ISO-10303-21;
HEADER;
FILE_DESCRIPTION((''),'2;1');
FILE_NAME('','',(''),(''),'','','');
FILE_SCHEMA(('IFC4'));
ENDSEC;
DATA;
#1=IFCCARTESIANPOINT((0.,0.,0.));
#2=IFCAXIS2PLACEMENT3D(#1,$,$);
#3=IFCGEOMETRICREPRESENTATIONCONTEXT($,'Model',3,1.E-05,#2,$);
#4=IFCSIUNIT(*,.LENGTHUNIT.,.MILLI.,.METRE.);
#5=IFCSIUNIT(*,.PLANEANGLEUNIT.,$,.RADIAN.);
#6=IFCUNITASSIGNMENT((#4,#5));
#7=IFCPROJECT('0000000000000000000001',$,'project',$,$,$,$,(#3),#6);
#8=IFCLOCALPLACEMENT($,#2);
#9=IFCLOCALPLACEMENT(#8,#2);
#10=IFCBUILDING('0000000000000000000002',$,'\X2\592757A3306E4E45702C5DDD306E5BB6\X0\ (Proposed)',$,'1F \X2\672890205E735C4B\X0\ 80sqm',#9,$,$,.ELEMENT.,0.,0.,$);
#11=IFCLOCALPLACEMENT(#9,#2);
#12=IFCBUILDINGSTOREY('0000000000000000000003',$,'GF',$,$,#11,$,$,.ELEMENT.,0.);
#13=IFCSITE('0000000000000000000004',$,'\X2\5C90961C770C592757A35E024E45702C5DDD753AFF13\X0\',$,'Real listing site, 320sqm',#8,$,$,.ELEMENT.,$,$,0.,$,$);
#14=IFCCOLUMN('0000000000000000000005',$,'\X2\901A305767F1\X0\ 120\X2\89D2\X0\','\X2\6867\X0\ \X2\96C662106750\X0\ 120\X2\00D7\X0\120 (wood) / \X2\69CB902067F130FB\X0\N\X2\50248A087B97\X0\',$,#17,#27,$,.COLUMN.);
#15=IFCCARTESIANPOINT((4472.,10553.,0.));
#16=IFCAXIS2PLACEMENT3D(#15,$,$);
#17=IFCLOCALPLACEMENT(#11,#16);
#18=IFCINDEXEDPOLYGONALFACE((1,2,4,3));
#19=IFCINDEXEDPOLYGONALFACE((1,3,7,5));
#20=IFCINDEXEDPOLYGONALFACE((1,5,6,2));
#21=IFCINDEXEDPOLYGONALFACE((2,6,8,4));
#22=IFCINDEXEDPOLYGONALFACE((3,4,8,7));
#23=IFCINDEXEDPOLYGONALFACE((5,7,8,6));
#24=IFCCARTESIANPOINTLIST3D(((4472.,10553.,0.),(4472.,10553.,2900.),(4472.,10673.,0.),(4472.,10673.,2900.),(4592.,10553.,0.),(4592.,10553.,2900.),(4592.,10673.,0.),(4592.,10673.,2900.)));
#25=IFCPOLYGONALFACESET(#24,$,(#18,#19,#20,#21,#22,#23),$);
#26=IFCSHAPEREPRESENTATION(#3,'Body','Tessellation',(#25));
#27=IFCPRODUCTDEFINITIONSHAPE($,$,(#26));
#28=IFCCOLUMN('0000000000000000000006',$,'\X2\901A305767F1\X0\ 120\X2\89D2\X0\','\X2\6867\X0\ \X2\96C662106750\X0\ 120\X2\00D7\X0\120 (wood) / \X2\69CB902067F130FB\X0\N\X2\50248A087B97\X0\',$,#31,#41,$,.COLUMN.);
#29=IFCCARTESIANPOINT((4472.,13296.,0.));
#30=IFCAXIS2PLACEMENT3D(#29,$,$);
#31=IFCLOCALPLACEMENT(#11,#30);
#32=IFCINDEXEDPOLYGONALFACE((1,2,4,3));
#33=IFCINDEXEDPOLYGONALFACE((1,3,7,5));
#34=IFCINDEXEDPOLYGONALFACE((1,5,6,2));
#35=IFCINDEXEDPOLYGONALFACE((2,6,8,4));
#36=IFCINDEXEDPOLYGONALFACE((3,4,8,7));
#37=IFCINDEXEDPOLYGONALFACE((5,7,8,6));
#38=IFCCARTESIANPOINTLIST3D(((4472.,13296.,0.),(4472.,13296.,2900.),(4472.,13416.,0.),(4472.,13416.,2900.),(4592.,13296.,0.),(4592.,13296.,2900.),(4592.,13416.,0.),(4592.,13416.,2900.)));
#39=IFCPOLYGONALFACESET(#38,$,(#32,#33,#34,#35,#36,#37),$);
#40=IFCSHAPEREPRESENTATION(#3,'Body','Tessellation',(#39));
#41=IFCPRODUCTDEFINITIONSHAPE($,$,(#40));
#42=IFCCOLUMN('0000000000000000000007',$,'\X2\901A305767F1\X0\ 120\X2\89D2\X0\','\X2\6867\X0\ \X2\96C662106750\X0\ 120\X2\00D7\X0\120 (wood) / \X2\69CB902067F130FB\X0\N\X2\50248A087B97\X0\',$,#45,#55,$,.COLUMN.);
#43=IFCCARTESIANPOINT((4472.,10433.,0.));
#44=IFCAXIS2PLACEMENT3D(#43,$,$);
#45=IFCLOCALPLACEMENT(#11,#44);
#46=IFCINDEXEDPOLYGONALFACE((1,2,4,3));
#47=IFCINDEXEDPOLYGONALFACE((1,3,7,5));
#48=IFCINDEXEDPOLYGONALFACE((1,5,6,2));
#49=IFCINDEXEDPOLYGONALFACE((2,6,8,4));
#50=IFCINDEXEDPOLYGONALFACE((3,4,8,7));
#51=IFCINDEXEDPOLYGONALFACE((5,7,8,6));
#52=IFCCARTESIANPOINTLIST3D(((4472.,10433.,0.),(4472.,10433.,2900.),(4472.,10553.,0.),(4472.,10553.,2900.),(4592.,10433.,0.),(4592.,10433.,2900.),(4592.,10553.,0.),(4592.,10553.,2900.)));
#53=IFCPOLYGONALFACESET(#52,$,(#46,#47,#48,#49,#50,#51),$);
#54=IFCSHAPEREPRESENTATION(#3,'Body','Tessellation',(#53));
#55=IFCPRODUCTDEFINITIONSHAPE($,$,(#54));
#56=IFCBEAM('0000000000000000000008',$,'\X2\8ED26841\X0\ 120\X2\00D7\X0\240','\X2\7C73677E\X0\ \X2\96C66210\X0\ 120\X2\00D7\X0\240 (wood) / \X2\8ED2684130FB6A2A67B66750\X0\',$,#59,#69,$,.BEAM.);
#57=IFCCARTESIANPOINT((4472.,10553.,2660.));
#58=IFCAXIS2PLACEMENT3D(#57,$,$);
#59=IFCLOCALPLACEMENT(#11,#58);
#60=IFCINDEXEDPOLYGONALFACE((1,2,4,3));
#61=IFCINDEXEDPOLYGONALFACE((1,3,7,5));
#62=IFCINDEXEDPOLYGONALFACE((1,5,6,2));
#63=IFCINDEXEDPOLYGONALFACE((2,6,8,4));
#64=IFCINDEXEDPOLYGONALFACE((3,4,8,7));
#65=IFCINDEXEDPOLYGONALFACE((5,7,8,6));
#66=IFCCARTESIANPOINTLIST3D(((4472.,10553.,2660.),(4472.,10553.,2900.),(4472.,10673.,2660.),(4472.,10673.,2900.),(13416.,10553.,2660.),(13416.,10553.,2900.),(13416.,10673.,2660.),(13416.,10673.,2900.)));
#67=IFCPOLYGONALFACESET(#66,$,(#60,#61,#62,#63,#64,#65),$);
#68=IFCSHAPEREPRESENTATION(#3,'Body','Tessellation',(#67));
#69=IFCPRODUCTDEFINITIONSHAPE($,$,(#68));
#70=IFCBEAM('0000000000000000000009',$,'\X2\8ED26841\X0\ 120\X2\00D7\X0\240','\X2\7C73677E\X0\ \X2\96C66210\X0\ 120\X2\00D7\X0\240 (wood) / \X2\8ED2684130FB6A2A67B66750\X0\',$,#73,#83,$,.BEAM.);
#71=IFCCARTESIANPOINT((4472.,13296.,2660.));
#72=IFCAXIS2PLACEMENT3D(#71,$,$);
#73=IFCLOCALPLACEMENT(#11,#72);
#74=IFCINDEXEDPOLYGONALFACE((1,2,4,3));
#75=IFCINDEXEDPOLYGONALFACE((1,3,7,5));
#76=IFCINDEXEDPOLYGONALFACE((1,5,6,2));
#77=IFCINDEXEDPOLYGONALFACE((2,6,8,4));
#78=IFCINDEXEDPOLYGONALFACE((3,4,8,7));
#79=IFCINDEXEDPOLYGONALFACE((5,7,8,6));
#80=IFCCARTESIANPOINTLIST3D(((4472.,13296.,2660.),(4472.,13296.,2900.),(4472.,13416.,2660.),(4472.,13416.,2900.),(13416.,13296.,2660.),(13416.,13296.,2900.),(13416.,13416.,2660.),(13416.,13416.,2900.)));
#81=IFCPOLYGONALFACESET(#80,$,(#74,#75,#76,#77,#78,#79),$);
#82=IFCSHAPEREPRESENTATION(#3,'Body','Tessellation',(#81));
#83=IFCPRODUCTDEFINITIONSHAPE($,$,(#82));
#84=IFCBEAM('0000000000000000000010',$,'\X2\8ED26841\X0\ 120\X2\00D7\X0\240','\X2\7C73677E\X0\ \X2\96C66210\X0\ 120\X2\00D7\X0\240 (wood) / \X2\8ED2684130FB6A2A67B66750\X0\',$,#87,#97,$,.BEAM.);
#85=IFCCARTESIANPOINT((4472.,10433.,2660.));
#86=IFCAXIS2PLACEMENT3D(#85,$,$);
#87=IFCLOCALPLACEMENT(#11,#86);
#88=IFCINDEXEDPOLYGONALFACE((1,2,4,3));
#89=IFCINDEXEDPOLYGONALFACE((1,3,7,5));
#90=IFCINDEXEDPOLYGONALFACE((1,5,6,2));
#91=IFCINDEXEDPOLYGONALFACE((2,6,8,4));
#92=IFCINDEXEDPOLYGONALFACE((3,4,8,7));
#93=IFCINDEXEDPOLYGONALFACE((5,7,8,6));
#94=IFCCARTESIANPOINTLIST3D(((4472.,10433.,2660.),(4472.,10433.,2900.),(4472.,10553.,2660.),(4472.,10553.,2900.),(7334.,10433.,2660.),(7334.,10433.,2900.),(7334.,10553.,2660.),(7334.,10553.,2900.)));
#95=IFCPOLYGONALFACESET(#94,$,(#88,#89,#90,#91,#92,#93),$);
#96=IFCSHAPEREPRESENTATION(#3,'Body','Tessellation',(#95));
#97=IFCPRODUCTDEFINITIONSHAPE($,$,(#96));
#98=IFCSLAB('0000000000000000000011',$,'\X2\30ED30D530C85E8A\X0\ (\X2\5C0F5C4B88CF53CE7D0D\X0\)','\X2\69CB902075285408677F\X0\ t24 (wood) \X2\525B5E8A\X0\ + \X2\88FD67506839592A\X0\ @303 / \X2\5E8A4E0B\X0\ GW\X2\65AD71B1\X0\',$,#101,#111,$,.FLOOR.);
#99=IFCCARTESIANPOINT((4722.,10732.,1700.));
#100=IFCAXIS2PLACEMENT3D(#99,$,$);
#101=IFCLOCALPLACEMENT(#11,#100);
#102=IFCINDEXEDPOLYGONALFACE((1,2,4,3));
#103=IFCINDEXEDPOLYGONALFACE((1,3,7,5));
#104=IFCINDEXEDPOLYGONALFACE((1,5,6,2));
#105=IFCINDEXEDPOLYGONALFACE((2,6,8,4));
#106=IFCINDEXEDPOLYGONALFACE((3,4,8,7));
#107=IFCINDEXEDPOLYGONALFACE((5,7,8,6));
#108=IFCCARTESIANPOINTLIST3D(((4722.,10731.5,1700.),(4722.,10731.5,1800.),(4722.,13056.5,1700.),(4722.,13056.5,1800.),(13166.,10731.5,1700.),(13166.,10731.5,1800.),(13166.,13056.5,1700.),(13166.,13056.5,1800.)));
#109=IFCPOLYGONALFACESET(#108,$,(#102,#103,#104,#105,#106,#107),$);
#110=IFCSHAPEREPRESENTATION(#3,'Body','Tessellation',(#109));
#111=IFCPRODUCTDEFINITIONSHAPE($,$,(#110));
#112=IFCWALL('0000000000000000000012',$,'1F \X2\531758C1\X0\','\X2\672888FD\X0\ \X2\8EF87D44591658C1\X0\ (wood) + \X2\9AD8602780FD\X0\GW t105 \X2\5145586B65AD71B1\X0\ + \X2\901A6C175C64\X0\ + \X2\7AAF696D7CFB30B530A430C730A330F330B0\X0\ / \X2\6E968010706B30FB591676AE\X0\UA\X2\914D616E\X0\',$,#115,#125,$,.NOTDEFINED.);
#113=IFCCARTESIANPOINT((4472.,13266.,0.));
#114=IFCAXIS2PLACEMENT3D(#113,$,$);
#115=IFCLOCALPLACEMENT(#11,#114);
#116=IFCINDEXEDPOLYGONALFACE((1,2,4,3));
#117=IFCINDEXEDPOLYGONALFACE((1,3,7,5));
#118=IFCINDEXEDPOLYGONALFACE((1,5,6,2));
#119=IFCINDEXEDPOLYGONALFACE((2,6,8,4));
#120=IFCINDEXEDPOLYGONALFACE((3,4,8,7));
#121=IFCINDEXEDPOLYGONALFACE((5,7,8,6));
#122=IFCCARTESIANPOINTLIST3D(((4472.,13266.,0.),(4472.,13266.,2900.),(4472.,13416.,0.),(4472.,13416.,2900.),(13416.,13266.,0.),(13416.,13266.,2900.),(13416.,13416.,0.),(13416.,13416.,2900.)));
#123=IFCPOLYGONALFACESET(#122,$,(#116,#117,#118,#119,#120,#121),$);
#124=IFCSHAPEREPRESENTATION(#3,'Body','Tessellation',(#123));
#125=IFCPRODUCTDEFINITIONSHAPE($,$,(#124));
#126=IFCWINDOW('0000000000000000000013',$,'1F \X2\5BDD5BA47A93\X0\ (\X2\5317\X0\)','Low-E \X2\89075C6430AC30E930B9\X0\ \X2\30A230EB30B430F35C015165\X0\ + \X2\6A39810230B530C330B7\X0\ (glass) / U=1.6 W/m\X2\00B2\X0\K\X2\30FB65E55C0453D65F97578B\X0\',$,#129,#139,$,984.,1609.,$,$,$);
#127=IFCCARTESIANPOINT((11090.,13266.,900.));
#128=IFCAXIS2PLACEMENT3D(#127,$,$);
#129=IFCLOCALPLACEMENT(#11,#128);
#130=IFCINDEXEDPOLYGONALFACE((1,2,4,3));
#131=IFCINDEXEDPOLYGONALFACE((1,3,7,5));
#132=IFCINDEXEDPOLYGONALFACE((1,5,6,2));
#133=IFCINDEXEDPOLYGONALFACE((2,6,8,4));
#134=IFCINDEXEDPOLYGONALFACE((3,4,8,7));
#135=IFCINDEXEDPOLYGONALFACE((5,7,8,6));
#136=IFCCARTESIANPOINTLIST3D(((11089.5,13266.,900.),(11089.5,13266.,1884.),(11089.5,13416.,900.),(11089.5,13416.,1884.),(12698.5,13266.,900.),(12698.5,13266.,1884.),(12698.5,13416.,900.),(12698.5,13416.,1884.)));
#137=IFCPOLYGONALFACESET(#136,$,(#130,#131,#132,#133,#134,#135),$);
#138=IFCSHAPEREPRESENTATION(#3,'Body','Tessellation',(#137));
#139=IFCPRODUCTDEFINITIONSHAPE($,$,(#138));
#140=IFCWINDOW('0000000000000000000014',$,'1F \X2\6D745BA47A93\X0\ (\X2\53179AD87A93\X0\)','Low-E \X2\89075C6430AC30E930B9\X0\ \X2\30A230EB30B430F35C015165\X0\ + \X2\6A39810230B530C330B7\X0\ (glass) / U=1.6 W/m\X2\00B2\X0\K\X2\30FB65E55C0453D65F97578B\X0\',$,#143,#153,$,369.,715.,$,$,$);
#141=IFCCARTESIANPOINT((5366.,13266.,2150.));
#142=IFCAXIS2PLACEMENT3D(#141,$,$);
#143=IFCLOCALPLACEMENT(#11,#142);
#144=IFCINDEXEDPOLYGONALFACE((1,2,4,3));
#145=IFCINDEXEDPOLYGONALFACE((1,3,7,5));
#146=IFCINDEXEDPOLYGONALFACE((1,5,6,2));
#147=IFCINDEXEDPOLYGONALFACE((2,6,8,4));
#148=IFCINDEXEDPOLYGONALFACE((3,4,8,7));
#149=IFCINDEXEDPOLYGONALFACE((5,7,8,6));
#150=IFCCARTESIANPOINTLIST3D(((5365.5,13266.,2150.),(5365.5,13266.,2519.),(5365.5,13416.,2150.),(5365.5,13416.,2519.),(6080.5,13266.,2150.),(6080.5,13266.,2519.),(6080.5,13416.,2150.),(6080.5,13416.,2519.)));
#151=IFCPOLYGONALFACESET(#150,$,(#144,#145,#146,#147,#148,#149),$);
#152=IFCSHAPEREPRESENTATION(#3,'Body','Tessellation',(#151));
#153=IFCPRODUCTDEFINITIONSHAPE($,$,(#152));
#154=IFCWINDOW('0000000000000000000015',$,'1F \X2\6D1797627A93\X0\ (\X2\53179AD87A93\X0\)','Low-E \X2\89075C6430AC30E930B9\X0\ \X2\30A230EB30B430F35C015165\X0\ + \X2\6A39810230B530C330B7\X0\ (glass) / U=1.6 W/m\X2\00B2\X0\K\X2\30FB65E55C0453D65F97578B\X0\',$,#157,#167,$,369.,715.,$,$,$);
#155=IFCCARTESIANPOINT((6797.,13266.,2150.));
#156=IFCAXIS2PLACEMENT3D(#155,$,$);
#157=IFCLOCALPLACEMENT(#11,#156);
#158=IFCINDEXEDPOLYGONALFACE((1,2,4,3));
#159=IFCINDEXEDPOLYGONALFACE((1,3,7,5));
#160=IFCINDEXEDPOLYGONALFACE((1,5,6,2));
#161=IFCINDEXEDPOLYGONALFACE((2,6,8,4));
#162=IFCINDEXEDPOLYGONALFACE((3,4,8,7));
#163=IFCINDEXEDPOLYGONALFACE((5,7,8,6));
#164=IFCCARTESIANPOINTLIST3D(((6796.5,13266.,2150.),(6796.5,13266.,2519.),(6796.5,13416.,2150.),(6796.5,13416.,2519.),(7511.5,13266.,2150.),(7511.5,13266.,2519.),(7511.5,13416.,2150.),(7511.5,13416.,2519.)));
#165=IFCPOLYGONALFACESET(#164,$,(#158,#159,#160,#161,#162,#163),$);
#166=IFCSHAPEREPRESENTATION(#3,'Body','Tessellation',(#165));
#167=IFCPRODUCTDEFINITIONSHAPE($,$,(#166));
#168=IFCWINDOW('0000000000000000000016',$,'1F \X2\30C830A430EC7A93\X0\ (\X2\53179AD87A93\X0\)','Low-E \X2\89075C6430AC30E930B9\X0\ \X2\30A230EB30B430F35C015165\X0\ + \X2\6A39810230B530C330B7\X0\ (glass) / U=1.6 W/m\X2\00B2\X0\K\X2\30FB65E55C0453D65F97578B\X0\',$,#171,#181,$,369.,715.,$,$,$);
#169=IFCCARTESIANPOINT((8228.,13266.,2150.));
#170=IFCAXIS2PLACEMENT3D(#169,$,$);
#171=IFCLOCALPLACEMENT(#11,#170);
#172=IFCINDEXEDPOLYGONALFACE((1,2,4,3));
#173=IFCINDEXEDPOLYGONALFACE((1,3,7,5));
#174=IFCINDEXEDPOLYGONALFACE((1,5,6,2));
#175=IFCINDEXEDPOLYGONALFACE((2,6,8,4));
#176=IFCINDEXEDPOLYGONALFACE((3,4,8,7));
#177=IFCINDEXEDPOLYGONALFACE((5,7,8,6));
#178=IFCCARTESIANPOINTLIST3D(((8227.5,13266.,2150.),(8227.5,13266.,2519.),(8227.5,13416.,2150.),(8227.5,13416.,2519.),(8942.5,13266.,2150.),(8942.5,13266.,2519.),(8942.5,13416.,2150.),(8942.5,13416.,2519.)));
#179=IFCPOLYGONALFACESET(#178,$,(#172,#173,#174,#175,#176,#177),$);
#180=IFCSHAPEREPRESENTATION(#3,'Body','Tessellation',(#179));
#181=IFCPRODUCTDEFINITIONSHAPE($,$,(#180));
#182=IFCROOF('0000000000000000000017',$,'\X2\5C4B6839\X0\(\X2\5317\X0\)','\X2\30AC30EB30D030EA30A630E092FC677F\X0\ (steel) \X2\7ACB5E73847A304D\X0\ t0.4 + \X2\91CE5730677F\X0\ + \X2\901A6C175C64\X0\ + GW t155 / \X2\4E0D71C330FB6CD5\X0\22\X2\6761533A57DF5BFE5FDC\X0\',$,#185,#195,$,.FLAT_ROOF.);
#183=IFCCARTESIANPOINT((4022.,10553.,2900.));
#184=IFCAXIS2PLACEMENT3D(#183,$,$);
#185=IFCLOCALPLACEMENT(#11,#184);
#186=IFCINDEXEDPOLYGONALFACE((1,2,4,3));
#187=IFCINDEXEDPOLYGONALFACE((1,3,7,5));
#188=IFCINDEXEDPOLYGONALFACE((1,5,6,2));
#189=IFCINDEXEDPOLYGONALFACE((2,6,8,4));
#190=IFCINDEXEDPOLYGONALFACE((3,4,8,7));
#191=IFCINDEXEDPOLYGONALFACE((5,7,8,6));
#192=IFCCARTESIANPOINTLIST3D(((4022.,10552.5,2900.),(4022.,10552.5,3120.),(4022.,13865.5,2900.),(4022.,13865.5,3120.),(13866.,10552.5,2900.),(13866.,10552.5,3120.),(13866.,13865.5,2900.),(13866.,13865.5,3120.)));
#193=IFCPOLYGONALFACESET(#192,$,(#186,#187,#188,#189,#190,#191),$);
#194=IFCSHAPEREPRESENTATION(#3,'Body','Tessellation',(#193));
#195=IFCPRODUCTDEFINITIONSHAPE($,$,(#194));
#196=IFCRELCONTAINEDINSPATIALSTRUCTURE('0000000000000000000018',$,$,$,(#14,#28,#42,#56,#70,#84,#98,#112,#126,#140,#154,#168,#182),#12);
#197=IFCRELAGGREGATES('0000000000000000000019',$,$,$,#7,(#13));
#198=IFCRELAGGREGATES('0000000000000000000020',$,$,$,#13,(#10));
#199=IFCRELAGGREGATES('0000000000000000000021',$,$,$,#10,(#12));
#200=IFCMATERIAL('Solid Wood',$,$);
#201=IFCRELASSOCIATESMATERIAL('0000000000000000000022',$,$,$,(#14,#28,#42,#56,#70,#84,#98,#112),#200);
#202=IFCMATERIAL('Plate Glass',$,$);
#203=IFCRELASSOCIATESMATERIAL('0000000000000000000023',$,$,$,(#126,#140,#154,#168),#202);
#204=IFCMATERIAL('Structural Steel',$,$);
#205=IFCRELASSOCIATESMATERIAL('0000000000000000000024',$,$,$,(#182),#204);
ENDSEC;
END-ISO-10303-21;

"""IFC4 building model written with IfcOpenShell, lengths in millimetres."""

from ifc_helpers import new_model, si_unit, frame, frame_2d, origin, place, context, project, spatial, rectangle, extrude, material, element, fill, save


model = new_model("IFC4")

# Units and contexts
model_context = context("Model", 3, precision=1e-05, world=origin())
ifc_project = project(units=[si_unit("LENGTHUNIT", "METRE", prefix="MILLI"), si_unit("PLANEANGLEUNIT", "RADIAN")], contexts=[model_context])

# Site, building, storey
site_placement = place(None, origin())
site = spatial("IfcSite", under=ifc_project, at=site_placement, Name="岐阜県大垣市久瀬川町３", ObjectType="Real listing site, 320sqm", CompositionType="ELEMENT", RefElevation=0.0)
building_placement = place(site_placement, origin())
building = spatial("IfcBuilding", under=site, at=building_placement, Name="大垣の久瀬川の家 (Proposed)", ObjectType="1F 木造平屋 80sqm", CompositionType="ELEMENT", ElevationOfRefHeight=0.0, ElevationOfTerrain=0.0)
storey_placement = place(building_placement, origin())
storey = spatial("IfcBuildingStorey", under=building, at=storey_placement, Name="GF", CompositionType="ELEMENT", Elevation=0.0)

# Columns
ifc_material_1 = material(Name="Solid Wood")
column_1_placement = place(storey_placement, frame((4472.0, 10553.0, 0.0)))
element("IfcColumn", 1, at=column_1_placement, inside=storey, material=ifc_material_1, Name="通し柱 120角", Description="桧 集成材 120×120 (wood) / 構造柱・N値計算", PredefinedType="COLUMN", context=model_context, shape_type="SweptSolid", body=[
    extrude(rectangle(XDim=120.0, YDim=120.0, at=frame_2d((60.0, 60.0))), frame((4472.0, 10553.0, 0.0)), (0.0, 0.0, 1.0), 2900.0),
])
column_2_placement = place(storey_placement, frame((4472.0, 13296.0, 0.0)))
element("IfcColumn", 2, at=column_2_placement, inside=storey, material=ifc_material_1, Name="通し柱 120角", Description="桧 集成材 120×120 (wood) / 構造柱・N値計算", PredefinedType="COLUMN", context=model_context, shape_type="SweptSolid", body=[
    extrude(rectangle(XDim=120.0, YDim=120.0, at=frame_2d((60.0, 60.0))), frame((4472.0, 13296.0, 0.0)), (0.0, 0.0, 1.0), 2900.0),
])
column_3_placement = place(storey_placement, frame((4472.0, 10433.0, 0.0)))
element("IfcColumn", 3, at=column_3_placement, inside=storey, material=ifc_material_1, Name="通し柱 120角", Description="桧 集成材 120×120 (wood) / 構造柱・N値計算", PredefinedType="COLUMN", context=model_context, shape_type="SweptSolid", body=[
    extrude(rectangle(XDim=120.0, YDim=120.0, at=frame_2d((60.0, 60.0))), frame((4472.0, 10433.0, 0.0)), (0.0, 0.0, 1.0), 2900.0),
])

# Beams
beam_1_placement = place(storey_placement, frame((4472.0, 10553.0, 2660.0)))
element("IfcBeam", 4, at=beam_1_placement, inside=storey, material=ifc_material_1, Name="軒桁 120×240", Description="米松 集成 120×240 (wood) / 軒桁・横架材", PredefinedType="BEAM", context=model_context, shape_type="SweptSolid", body=[
    extrude(rectangle(XDim=8944.0, YDim=120.0, at=frame_2d((4472.0, 60.0))), frame((4472.0, 10553.0, 2660.0)), (0.0, 0.0, 1.0), 240.0),
])
beam_2_placement = place(storey_placement, frame((4472.0, 13296.0, 2660.0)))
element("IfcBeam", 5, at=beam_2_placement, inside=storey, material=ifc_material_1, Name="軒桁 120×240", Description="米松 集成 120×240 (wood) / 軒桁・横架材", PredefinedType="BEAM", context=model_context, shape_type="SweptSolid", body=[
    extrude(rectangle(XDim=8944.0, YDim=120.0, at=frame_2d((4472.0, 60.0))), frame((4472.0, 13296.0, 2660.0)), (0.0, 0.0, 1.0), 240.0),
])
beam_3_placement = place(storey_placement, frame((4472.0, 10433.0, 2660.0)))
element("IfcBeam", 6, at=beam_3_placement, inside=storey, material=ifc_material_1, Name="軒桁 120×240", Description="米松 集成 120×240 (wood) / 軒桁・横架材", PredefinedType="BEAM", context=model_context, shape_type="SweptSolid", body=[
    extrude(rectangle(XDim=2862.0, YDim=120.0, at=frame_2d((1431.0, 60.0))), frame((4472.0, 10433.0, 2660.0)), (0.0, 0.0, 1.0), 240.0),
])

# Slab
slab_1_placement = place(storey_placement, frame((4722.0, 10732.0, 1700.0)))
element("IfcSlab", 7, at=slab_1_placement, inside=storey, material=ifc_material_1, Name="ロフト床 (小屋裏収納)", Description="構造用合板 t24 (wood) 剛床 + 製材根太 @303 / 床下 GW断熱", PredefinedType="FLOOR", context=model_context, shape_type="SweptSolid", body=[
    extrude(rectangle(XDim=8444.0, YDim=2325.0, at=frame_2d((4222.0, 1162.0))), frame((4722.0, 10732.0, 1700.0)), (0.0, 0.0, 1.0), 100.0),
])

# Wall, openings, windows
wall_1_placement = place(storey_placement, frame((4472.0, 13266.0, 0.0)))
wall_1 = element("IfcWall", 8, at=wall_1_placement, inside=storey, material=ifc_material_1, Name="1F 北壁", Description="木製 軸組外壁 (wood) + 高性能GW t105 充填断熱 + 通気層 + 窯業系サイディング / 準耐火・外皮UA配慮", PredefinedType="NOTDEFINED", context=model_context, shape_type="SweptSolid", body=[
    extrude(rectangle(XDim=8944.0, YDim=150.0, at=frame_2d((4472.0, 75.0))), frame((4472.0, 13266.0, 0.0)), (0.0, 0.0, 1.0), 2900.0),
])
opening_1_placement = place(storey_placement, frame((11090.0, 13266.0, 900.0)))
opening_1 = element("IfcOpeningElement", 9, at=opening_1_placement, cuts=wall_1, PredefinedType="NOTDEFINED", context=model_context, shape_type="SweptSolid", body=[
    extrude(rectangle(XDim=1609.0, YDim=150.0, at=frame_2d((804.0, 75.0))), frame((11090.0, 13266.0, 900.0)), (0.0, 0.0, 1.0), 984.0),
])
opening_2_placement = place(storey_placement, frame((5366.0, 13266.0, 2150.0)))
opening_2 = element("IfcOpeningElement", 10, at=opening_2_placement, cuts=wall_1, PredefinedType="NOTDEFINED", context=model_context, shape_type="SweptSolid", body=[
    extrude(rectangle(XDim=715.0, YDim=150.0, at=frame_2d((357.0, 75.0))), frame((5366.0, 13266.0, 2150.0)), (0.0, 0.0, 1.0), 369.0),
])
opening_3_placement = place(storey_placement, frame((6797.0, 13266.0, 2150.0)))
opening_3 = element("IfcOpeningElement", 11, at=opening_3_placement, cuts=wall_1, PredefinedType="NOTDEFINED", context=model_context, shape_type="SweptSolid", body=[
    extrude(rectangle(XDim=715.0, YDim=150.0, at=frame_2d((357.0, 75.0))), frame((6797.0, 13266.0, 2150.0)), (0.0, 0.0, 1.0), 369.0),
])
opening_4_placement = place(storey_placement, frame((8228.0, 13266.0, 2150.0)))
opening_4 = element("IfcOpeningElement", 12, at=opening_4_placement, cuts=wall_1, PredefinedType="NOTDEFINED", context=model_context, shape_type="SweptSolid", body=[
    extrude(rectangle(XDim=715.0, YDim=150.0, at=frame_2d((357.0, 75.0))), frame((8228.0, 13266.0, 2150.0)), (0.0, 0.0, 1.0), 369.0),
])
ifc_material_2 = material(Name="Plate Glass")
window_1_placement = place(storey_placement, frame((11090.0, 13266.0, 900.0)))
window_1 = element("IfcWindow", 13, at=window_1_placement, inside=storey, material=ifc_material_2, Name="1F 寝室窓 (北)", Description="Low-E 複層ガラス アルゴン封入 + 樹脂サッシ (glass) / U=1.6 W/m²K・日射取得型", OverallHeight=984.0, OverallWidth=1609.0, context=model_context, shape_type="SweptSolid", body=[
    extrude(rectangle(XDim=1609.0, YDim=150.0, at=frame_2d((804.0, 75.0))), frame((11090.0, 13266.0, 900.0)), (0.0, 0.0, 1.0), 984.0),
])
fill(opening_1, window_1)
window_2_placement = place(storey_placement, frame((5366.0, 13266.0, 2150.0)))
window_2 = element("IfcWindow", 14, at=window_2_placement, inside=storey, material=ifc_material_2, Name="1F 浴室窓 (北高窓)", Description="Low-E 複層ガラス アルゴン封入 + 樹脂サッシ (glass) / U=1.6 W/m²K・日射取得型", OverallHeight=369.0, OverallWidth=715.0, context=model_context, shape_type="SweptSolid", body=[
    extrude(rectangle(XDim=715.0, YDim=150.0, at=frame_2d((357.0, 75.0))), frame((5366.0, 13266.0, 2150.0)), (0.0, 0.0, 1.0), 369.0),
])
fill(opening_2, window_2)
window_3_placement = place(storey_placement, frame((6797.0, 13266.0, 2150.0)))
window_3 = element("IfcWindow", 15, at=window_3_placement, inside=storey, material=ifc_material_2, Name="1F 洗面窓 (北高窓)", Description="Low-E 複層ガラス アルゴン封入 + 樹脂サッシ (glass) / U=1.6 W/m²K・日射取得型", OverallHeight=369.0, OverallWidth=715.0, context=model_context, shape_type="SweptSolid", body=[
    extrude(rectangle(XDim=715.0, YDim=150.0, at=frame_2d((357.0, 75.0))), frame((6797.0, 13266.0, 2150.0)), (0.0, 0.0, 1.0), 369.0),
])
fill(opening_3, window_3)
window_4_placement = place(storey_placement, frame((8228.0, 13266.0, 2150.0)))
window_4 = element("IfcWindow", 16, at=window_4_placement, inside=storey, material=ifc_material_2, Name="1F トイレ窓 (北高窓)", Description="Low-E 複層ガラス アルゴン封入 + 樹脂サッシ (glass) / U=1.6 W/m²K・日射取得型", OverallHeight=369.0, OverallWidth=715.0, context=model_context, shape_type="SweptSolid", body=[
    extrude(rectangle(XDim=715.0, YDim=150.0, at=frame_2d((357.0, 75.0))), frame((8228.0, 13266.0, 2150.0)), (0.0, 0.0, 1.0), 369.0),
])
fill(opening_4, window_4)

# Roof
ifc_material_3 = material(Name="Structural Steel")
roof_placement = place(storey_placement, frame((4022.0, 10553.0, 2900.0)))
element("IfcRoof", 17, at=roof_placement, inside=storey, material=ifc_material_3, Name="屋根(北)", Description="ガルバリウム鋼板 (steel) 立平葺き t0.4 + 野地板 + 通気層 + GW t155 / 不燃・法22条区域対応", PredefinedType="FLAT_ROOF", context=model_context, shape_type="SweptSolid", body=[
    extrude(rectangle(XDim=9844.0, YDim=3313.0, at=frame_2d((4922.0, 1656.0))), frame((4022.0, 10553.0, 2900.0)), (0.0, 0.0, 1.0), 220.0),
])

save(model, "model.ifc")
